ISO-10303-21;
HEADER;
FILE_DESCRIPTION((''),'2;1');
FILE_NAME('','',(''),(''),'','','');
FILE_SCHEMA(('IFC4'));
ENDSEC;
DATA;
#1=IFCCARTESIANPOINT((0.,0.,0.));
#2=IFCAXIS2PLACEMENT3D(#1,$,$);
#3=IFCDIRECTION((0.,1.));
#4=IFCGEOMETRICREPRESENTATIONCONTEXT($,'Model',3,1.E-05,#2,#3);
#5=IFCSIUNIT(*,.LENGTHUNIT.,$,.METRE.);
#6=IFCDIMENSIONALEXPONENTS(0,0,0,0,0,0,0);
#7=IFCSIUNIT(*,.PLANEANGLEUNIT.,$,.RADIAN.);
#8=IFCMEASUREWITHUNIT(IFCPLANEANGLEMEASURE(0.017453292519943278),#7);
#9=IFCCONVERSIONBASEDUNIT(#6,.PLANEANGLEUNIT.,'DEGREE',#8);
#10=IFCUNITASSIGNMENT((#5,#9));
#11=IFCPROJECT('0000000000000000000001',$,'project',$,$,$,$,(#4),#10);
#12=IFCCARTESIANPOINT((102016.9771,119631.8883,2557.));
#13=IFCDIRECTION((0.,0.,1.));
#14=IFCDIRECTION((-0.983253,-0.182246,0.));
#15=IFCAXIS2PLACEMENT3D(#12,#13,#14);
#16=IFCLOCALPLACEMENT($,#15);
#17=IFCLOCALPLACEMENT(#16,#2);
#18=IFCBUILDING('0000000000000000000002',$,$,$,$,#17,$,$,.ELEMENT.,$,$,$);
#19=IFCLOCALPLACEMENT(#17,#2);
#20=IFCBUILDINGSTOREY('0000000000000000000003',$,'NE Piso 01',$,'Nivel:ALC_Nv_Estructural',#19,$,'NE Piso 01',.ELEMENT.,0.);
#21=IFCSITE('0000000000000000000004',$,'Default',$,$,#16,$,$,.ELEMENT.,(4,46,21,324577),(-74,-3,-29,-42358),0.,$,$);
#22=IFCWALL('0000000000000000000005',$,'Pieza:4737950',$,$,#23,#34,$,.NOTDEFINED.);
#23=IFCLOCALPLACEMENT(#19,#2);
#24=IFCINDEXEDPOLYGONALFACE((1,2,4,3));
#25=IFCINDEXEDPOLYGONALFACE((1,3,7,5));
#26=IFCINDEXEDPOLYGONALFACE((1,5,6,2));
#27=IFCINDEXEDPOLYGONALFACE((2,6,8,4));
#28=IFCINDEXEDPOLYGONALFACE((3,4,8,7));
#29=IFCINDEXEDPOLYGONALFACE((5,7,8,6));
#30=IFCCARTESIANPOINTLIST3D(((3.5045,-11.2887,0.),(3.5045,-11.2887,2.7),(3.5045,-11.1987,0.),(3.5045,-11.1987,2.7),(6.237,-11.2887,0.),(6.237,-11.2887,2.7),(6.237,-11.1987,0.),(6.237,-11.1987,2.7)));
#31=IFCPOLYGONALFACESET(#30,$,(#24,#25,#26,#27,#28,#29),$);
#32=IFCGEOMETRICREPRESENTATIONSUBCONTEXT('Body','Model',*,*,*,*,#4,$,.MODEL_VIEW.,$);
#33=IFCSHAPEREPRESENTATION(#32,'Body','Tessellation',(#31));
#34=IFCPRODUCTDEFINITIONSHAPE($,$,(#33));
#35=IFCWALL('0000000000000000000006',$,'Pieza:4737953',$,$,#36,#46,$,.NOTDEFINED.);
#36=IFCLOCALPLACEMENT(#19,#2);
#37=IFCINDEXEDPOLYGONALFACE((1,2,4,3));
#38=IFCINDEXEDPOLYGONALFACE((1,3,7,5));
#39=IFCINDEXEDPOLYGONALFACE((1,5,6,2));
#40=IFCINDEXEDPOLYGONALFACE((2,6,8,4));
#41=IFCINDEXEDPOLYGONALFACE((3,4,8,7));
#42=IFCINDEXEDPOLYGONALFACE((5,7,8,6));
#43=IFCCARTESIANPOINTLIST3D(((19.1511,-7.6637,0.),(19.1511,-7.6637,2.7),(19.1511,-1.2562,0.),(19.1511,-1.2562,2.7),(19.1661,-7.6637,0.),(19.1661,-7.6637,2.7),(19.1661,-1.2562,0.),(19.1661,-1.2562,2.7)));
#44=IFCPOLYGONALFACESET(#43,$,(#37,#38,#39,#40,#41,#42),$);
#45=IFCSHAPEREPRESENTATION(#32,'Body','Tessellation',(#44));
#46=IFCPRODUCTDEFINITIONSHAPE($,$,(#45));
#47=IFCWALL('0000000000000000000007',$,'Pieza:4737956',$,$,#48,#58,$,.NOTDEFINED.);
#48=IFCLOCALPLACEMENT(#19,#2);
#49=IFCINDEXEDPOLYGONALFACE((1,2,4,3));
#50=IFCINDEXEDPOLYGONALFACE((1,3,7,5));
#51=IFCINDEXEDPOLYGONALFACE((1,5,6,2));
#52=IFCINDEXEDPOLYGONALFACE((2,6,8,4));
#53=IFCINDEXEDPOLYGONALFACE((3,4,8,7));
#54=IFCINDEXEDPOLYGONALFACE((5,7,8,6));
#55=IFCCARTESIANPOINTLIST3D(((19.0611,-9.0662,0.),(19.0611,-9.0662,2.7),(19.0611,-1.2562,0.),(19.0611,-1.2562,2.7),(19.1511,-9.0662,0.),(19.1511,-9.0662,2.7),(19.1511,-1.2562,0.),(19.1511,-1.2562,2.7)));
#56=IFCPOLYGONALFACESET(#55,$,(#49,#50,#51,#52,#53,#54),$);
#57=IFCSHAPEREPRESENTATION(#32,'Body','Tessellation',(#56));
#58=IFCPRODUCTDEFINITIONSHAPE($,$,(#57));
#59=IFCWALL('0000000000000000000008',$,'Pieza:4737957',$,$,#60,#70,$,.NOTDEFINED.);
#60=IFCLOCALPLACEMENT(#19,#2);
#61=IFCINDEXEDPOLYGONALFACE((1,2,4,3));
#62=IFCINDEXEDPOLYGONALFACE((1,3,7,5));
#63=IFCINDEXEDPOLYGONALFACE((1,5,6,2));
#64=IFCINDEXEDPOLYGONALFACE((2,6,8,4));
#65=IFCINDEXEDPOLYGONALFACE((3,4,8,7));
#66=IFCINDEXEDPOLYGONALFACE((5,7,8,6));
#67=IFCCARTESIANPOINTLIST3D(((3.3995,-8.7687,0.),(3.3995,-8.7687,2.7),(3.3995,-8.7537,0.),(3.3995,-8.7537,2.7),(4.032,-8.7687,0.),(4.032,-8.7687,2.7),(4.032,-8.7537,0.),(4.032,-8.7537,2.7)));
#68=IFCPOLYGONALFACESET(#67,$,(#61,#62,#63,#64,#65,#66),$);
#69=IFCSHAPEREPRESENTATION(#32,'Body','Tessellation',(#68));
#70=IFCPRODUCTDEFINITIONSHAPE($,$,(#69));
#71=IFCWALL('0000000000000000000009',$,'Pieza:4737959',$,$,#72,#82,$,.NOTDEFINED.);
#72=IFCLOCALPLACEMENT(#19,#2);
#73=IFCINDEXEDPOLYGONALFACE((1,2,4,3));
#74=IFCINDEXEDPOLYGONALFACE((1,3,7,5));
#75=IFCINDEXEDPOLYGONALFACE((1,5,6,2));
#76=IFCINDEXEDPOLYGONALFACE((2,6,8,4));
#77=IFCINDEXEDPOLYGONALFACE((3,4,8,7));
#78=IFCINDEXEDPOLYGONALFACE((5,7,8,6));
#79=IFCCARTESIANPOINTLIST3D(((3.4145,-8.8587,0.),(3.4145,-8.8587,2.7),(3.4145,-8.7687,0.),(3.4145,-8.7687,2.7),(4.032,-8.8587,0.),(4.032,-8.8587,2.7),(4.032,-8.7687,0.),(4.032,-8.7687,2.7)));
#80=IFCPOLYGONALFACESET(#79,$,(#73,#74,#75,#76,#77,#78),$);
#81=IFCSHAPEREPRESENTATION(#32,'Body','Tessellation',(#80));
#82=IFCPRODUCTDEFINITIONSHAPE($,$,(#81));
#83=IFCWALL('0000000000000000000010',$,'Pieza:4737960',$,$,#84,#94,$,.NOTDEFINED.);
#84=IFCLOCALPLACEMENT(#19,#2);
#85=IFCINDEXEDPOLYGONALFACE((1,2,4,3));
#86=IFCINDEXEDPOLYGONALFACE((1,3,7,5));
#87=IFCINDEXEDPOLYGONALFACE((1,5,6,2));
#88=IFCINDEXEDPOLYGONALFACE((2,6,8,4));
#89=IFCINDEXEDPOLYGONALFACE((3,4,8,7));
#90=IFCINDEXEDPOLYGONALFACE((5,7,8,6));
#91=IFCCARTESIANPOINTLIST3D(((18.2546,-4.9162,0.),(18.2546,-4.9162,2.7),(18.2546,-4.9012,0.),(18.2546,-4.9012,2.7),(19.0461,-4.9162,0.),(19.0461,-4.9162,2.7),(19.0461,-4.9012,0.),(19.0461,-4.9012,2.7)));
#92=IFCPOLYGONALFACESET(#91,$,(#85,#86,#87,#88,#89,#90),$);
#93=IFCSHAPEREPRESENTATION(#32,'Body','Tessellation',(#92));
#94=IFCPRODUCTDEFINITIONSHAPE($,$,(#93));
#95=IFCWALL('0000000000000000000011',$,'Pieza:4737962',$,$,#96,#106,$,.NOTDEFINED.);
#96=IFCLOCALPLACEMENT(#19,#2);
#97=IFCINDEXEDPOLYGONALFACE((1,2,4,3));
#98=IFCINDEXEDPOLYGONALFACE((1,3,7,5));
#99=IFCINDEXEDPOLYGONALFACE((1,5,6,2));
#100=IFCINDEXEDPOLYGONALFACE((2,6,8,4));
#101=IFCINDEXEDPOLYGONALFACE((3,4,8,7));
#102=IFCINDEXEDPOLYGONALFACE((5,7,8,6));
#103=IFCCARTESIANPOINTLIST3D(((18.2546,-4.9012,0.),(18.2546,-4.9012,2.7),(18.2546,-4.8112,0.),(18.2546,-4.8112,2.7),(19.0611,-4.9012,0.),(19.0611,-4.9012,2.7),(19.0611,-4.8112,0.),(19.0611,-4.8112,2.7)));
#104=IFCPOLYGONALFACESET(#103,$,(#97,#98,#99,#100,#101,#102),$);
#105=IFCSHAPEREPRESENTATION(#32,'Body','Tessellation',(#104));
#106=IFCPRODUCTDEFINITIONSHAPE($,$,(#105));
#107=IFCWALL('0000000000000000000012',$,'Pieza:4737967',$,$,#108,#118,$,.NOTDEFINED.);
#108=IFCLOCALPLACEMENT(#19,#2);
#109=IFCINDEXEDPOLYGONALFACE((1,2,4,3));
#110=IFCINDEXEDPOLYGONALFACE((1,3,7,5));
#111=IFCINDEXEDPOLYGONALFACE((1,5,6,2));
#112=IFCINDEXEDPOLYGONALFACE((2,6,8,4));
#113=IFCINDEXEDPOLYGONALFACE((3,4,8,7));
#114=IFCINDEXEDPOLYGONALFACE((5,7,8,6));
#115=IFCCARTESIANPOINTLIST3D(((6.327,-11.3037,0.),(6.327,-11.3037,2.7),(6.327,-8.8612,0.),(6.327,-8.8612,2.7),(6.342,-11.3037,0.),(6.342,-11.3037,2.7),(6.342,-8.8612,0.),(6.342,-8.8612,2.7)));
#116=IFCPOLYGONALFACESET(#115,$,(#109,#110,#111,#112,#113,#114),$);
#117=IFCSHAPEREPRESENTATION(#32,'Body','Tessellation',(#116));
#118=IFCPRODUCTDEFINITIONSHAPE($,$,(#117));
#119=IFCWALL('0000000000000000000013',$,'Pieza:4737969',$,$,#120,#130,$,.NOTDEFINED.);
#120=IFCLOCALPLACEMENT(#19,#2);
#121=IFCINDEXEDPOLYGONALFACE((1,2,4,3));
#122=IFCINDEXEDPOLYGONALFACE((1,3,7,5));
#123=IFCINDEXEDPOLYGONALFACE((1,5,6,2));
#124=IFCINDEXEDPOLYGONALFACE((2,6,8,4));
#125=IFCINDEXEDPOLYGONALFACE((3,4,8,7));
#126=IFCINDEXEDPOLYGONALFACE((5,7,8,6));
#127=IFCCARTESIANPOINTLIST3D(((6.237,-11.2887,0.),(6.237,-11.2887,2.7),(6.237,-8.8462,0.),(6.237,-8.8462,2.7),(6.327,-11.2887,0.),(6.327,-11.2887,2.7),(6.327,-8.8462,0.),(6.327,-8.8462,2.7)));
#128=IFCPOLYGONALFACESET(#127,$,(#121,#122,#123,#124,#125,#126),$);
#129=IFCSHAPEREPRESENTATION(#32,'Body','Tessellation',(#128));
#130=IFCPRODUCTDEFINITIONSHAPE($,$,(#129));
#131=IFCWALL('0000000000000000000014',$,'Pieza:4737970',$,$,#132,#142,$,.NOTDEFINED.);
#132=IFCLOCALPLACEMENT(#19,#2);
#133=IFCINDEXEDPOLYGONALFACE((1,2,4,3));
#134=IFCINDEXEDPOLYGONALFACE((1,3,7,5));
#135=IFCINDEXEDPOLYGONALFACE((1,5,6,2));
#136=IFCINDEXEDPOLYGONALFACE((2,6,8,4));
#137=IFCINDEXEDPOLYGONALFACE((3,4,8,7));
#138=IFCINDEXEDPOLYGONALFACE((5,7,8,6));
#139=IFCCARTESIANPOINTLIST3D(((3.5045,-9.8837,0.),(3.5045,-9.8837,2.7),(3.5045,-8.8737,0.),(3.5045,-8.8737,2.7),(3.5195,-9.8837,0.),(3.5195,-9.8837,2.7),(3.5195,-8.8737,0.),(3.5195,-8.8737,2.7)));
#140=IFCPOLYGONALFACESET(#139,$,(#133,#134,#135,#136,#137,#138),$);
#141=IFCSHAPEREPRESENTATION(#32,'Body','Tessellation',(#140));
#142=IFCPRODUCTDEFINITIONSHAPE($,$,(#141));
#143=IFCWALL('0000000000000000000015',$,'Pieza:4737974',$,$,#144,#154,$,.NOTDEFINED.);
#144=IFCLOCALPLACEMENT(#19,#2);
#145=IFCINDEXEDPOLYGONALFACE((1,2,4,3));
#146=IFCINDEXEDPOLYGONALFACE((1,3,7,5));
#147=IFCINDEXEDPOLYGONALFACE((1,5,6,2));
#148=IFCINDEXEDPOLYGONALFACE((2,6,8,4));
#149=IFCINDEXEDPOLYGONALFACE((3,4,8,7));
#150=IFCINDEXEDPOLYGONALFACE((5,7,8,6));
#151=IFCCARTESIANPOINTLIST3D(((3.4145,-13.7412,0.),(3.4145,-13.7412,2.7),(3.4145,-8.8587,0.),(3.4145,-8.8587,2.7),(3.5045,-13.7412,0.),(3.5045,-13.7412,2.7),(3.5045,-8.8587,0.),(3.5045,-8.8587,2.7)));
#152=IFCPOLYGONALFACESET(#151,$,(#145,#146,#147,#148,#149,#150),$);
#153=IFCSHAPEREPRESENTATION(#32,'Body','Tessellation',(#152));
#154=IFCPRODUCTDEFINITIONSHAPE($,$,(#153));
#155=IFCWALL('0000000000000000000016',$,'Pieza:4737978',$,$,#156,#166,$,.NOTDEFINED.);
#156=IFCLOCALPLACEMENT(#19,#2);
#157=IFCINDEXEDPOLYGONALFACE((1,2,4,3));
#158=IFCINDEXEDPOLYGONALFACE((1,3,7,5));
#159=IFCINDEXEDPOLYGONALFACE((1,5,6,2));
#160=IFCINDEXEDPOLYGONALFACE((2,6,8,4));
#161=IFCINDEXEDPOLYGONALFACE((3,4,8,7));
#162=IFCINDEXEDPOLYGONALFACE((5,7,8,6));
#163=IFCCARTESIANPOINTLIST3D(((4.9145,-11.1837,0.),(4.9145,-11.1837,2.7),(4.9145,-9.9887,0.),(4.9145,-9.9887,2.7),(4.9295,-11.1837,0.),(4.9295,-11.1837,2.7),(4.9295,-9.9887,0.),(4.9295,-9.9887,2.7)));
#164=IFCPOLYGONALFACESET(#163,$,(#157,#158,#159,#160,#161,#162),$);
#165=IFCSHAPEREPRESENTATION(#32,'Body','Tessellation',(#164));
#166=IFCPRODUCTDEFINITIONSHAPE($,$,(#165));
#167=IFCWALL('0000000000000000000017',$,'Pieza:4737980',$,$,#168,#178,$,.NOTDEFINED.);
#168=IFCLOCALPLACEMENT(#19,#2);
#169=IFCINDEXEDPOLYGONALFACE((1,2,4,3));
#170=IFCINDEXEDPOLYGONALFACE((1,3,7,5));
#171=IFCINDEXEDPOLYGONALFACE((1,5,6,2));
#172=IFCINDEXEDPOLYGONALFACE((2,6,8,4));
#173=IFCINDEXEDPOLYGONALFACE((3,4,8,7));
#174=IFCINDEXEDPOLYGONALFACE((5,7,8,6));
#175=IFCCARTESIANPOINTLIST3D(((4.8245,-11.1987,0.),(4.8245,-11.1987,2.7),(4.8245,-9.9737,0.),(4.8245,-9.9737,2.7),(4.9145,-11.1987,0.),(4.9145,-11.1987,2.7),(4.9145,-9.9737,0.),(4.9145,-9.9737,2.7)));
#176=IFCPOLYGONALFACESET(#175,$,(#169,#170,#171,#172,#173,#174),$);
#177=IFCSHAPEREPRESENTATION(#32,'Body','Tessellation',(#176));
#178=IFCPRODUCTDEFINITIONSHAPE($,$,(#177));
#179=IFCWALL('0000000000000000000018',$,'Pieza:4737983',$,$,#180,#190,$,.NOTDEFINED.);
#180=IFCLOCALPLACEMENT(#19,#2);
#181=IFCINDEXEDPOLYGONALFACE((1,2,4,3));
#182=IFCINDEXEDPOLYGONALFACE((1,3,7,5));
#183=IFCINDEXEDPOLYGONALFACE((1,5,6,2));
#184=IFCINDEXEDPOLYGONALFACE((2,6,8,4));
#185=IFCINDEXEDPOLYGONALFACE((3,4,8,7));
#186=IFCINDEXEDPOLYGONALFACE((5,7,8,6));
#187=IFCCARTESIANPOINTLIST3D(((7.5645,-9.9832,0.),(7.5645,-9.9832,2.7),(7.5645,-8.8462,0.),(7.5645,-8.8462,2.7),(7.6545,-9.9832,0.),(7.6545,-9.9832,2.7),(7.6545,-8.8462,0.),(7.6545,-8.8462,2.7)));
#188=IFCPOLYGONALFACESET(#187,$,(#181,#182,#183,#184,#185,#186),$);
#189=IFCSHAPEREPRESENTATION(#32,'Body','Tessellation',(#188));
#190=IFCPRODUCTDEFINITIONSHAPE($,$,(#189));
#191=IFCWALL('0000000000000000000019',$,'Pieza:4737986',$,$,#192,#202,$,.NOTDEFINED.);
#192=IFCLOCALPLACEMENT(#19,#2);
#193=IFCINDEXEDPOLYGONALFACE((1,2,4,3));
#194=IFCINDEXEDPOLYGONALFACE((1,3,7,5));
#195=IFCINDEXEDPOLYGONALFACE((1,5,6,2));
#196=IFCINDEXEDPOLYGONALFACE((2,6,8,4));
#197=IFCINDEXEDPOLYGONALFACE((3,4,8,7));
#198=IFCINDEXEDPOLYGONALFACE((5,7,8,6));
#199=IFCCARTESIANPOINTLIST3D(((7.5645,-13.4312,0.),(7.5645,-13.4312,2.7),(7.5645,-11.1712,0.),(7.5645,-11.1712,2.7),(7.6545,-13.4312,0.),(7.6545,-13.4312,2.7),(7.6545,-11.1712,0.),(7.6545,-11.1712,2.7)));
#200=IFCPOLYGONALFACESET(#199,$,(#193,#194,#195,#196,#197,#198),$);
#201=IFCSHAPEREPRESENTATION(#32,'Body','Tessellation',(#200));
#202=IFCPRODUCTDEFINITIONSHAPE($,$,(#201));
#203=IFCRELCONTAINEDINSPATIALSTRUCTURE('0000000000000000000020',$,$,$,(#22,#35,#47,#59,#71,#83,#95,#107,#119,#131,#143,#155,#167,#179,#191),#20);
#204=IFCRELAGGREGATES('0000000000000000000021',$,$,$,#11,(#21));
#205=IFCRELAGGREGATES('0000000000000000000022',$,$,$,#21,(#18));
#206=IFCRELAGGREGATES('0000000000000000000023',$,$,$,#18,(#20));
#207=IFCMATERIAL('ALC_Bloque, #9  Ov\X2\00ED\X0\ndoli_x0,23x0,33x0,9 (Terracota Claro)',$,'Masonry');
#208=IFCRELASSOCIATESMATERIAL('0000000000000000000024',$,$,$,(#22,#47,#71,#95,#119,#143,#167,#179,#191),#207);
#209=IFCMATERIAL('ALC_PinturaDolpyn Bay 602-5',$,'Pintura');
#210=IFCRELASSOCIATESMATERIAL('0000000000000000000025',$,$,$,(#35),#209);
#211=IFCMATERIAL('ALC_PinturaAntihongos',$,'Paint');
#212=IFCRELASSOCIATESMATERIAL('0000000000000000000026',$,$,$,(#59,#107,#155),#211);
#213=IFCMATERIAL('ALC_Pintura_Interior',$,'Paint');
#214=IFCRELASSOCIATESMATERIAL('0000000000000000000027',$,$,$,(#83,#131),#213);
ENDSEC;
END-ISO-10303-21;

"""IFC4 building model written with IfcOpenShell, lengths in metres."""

from ifc_helpers import new_model, entity, si_unit, converted_unit, direction, frame, frame_2d, origin, place, context, subcontext, project, spatial, rectangle, extrude, material, element, save


model = new_model("IFC4")

# Units and contexts
model_context = context("Model", 3, precision=1e-05, world=origin(), true_north=direction((0.0, 1.0)))
body_context = subcontext(model_context, "Body", "Model", "MODEL_VIEW")
ifc_project = project(units=[si_unit("LENGTHUNIT", "METRE"), converted_unit("PLANEANGLEUNIT", "DEGREE", entity("IfcPlaneAngleMeasure", 0.017453292519943278), si_unit("PLANEANGLEUNIT", "RADIAN"), dimensions=[0, 0, 0, 0, 0, 0, 0])], contexts=[model_context])

# Site, building, storey
site_placement = place(None, frame((102016.9771, 119631.8883, 2557.0), z_axis=(0.0, 0.0, 1.0), x_axis=(-0.983253, -0.182246, 0.0)))
site = spatial("IfcSite", under=ifc_project, at=site_placement, Name="Default", CompositionType="ELEMENT", RefLatitude=(4, 46, 21, 324577), RefLongitude=(-74, -3, -29, -42358), RefElevation=0.0)
building_placement = place(site_placement, origin())
building = spatial("IfcBuilding", under=site, at=building_placement, CompositionType="ELEMENT")
storey_placement = place(building_placement, origin())
storey = spatial("IfcBuildingStorey", under=building, at=storey_placement, Name="NE Piso 01", ObjectType="Nivel:ALC_Nv_Estructural", LongName="NE Piso 01", CompositionType="ELEMENT", Elevation=0.0)

# Walls
ifc_material_1 = material(Name="ALC_Bloque, #9  Ovíndoli_x0,23x0,33x0,9 (Terracota Claro)", Category="Masonry")
ifc_material_2 = material(Name="ALC_Pintura_Interior", Category="Paint")
ifc_material_3 = material(Name="ALC_PinturaAntihongos", Category="Paint")
wall_1_placement = place(storey_placement, origin())
element("IfcWall", 1, at=wall_1_placement, inside=storey, material=ifc_material_1, Name="Pieza:4737950", PredefinedType="NOTDEFINED", context=body_context, shape_type="SweptSolid", body=[
    extrude(rectangle(XDim=0.09, YDim=2.7325, at=frame_2d((0.0, 0.0), x_axis=(1.0, 0.0))), frame((4.8708, -11.2437, 0.0), z_axis=(0.0, 0.0, 1.0), x_axis=(0.0, -1.0, 0.0)), (0.0, 0.0, 1.0), 2.7),
])
ifc_material_4 = material(Name="ALC_PinturaDolpyn Bay 602-5", Category="Pintura")
wall_2_placement = place(storey_placement, origin())
element("IfcWall", 2, at=wall_2_placement, inside=storey, material=ifc_material_4, Name="Pieza:4737953", PredefinedType="NOTDEFINED", context=body_context, shape_type="SweptSolid", body=[
    extrude(rectangle(XDim=6.4075, YDim=0.015, at=frame_2d((0.0, 0.0), x_axis=(1.0, 0.0))), frame((19.1586, -4.4599, 0.0), z_axis=(0.0, 0.0, 1.0), x_axis=(0.0, -1.0, 0.0)), (0.0, 0.0, 1.0), 2.7),
])
wall_3_placement = place(storey_placement, origin())
element("IfcWall", 3, at=wall_3_placement, inside=storey, material=ifc_material_1, Name="Pieza:4737956", PredefinedType="NOTDEFINED", context=body_context, shape_type="SweptSolid", body=[
    extrude(rectangle(XDim=7.81, YDim=0.09, at=frame_2d((0.0, 0.0), x_axis=(1.0, 0.0))), frame((19.1061, -5.1612, 0.0), z_axis=(0.0, 0.0, 1.0), x_axis=(0.0, -1.0, 0.0)), (0.0, 0.0, 1.0), 2.7),
])
wall_4_placement = place(storey_placement, origin())
element("IfcWall", 4, at=wall_4_placement, inside=storey, material=ifc_material_3, Name="Pieza:4737957", PredefinedType="NOTDEFINED", context=body_context, shape_type="SweptSolid", body=[
    extrude(rectangle(XDim=0.015, YDim=0.6325, at=frame_2d((0.0, 0.0), x_axis=(1.0, 0.0))), frame((3.7158, -8.7612, 0.0), z_axis=(0.0, 0.0, 1.0), x_axis=(0.0, -1.0, 0.0)), (0.0, 0.0, 1.0), 2.7),
])
wall_5_placement = place(storey_placement, origin())
element("IfcWall", 5, at=wall_5_placement, inside=storey, material=ifc_material_1, Name="Pieza:4737959", PredefinedType="NOTDEFINED", context=body_context, shape_type="SweptSolid", body=[
    extrude(rectangle(XDim=0.09, YDim=0.6175, at=frame_2d((0.0, 0.0), x_axis=(1.0, 0.0))), frame((3.7233, -8.8137, 0.0), z_axis=(0.0, 0.0, 1.0), x_axis=(0.0, -1.0, 0.0)), (0.0, 0.0, 1.0), 2.7),
])
wall_6_placement = place(storey_placement, origin())
element("IfcWall", 6, at=wall_6_placement, inside=storey, material=ifc_material_2, Name="Pieza:4737960", PredefinedType="NOTDEFINED", context=body_context, shape_type="SweptSolid", body=[
    extrude(rectangle(XDim=0.015, YDim=0.7915, at=frame_2d((0.0, 0.0), x_axis=(1.0, 0.0))), frame((18.6504, -4.9087, 0.0), z_axis=(0.0, 0.0, 1.0), x_axis=(0.0, -1.0, 0.0)), (0.0, 0.0, 1.0), 2.7),
])
wall_7_placement = place(storey_placement, origin())
element("IfcWall", 7, at=wall_7_placement, inside=storey, material=ifc_material_1, Name="Pieza:4737962", PredefinedType="NOTDEFINED", context=body_context, shape_type="SweptSolid", body=[
    extrude(rectangle(XDim=0.09, YDim=0.8065, at=frame_2d((0.0, 0.0), x_axis=(1.0, 0.0))), frame((18.6579, -4.8562, 0.0), z_axis=(0.0, 0.0, 1.0), x_axis=(0.0, -1.0, 0.0)), (0.0, 0.0, 1.0), 2.7),
])
wall_8_placement = place(storey_placement, origin())
element("IfcWall", 8, at=wall_8_placement, inside=storey, material=ifc_material_3, Name="Pieza:4737967", PredefinedType="NOTDEFINED", context=body_context, shape_type="SweptSolid", body=[
    extrude(rectangle(XDim=2.4425, YDim=0.015, at=frame_2d((0.0, 0.0), x_axis=(1.0, 0.0))), frame((6.3345, -10.0824, 0.0), z_axis=(0.0, 0.0, 1.0), x_axis=(0.0, -1.0, 0.0)), (0.0, 0.0, 1.0), 2.7),
])
wall_9_placement = place(storey_placement, origin())
element("IfcWall", 9, at=wall_9_placement, inside=storey, material=ifc_material_1, Name="Pieza:4737969", PredefinedType="NOTDEFINED", context=body_context, shape_type="SweptSolid", body=[
    extrude(rectangle(XDim=2.4425, YDim=0.09, at=frame_2d((0.0, 0.0), x_axis=(1.0, 0.0))), frame((6.282, -10.0674, 0.0), z_axis=(0.0, 0.0, 1.0), x_axis=(0.0, -1.0, 0.0)), (0.0, 0.0, 1.0), 2.7),
])
wall_10_placement = place(storey_placement, origin())
element("IfcWall", 10, at=wall_10_placement, inside=storey, material=ifc_material_2, Name="Pieza:4737970", PredefinedType="NOTDEFINED", context=body_context, shape_type="SweptSolid", body=[
    extrude(rectangle(XDim=1.01, YDim=0.015, at=frame_2d((0.0, 0.0), x_axis=(1.0, 0.0))), frame((3.512, -9.3787, 0.0), z_axis=(0.0, 0.0, 1.0), x_axis=(0.0, -1.0, 0.0)), (0.0, 0.0, 1.0), 2.7),
])
wall_11_placement = place(storey_placement, origin())
element("IfcWall", 11, at=wall_11_placement, inside=storey, material=ifc_material_1, Name="Pieza:4737974", PredefinedType="NOTDEFINED", context=body_context, shape_type="SweptSolid", body=[
    extrude(rectangle(XDim=4.8825, YDim=0.09, at=frame_2d((0.0, 0.0), x_axis=(1.0, 0.0))), frame((3.4595, -11.2999, 0.0), z_axis=(0.0, 0.0, 1.0), x_axis=(0.0, -1.0, 0.0)), (0.0, 0.0, 1.0), 2.7),
])
wall_12_placement = place(storey_placement, origin())
element("IfcWall", 12, at=wall_12_placement, inside=storey, material=ifc_material_3, Name="Pieza:4737978", PredefinedType="NOTDEFINED", context=body_context, shape_type="SweptSolid", body=[
    extrude(rectangle(XDim=1.195, YDim=0.015, at=frame_2d((0.0, 0.0), x_axis=(1.0, 0.0))), frame((4.922, -10.5862, 0.0), z_axis=(0.0, 0.0, 1.0), x_axis=(0.0, -1.0, 0.0)), (0.0, 0.0, 1.0), 2.7),
])
wall_13_placement = place(storey_placement, origin())
element("IfcWall", 13, at=wall_13_placement, inside=storey, material=ifc_material_1, Name="Pieza:4737980", PredefinedType="NOTDEFINED", context=body_context, shape_type="SweptSolid", body=[
    extrude(rectangle(XDim=1.225, YDim=0.09, at=frame_2d((0.0, 0.0), x_axis=(1.0, 0.0))), frame((4.8695, -10.5862, 0.0), z_axis=(0.0, 0.0, 1.0), x_axis=(0.0, -1.0, 0.0)), (0.0, 0.0, 1.0), 2.7),
])
wall_14_placement = place(storey_placement, origin())
element("IfcWall", 14, at=wall_14_placement, inside=storey, material=ifc_material_1, Name="Pieza:4737983", PredefinedType="NOTDEFINED", context=body_context, shape_type="SweptSolid", body=[
    extrude(rectangle(XDim=1.137, YDim=0.09, at=frame_2d((0.0, 0.0), x_axis=(1.0, 0.0))), frame((7.6095, -9.4147, 0.0), z_axis=(0.0, 0.0, 1.0), x_axis=(0.0, -1.0, 0.0)), (0.0, 0.0, 1.0), 2.7),
])
wall_15_placement = place(storey_placement, origin())
element("IfcWall", 15, at=wall_15_placement, inside=storey, material=ifc_material_1, Name="Pieza:4737986", PredefinedType="NOTDEFINED", context=body_context, shape_type="SweptSolid", body=[
    extrude(rectangle(XDim=2.26, YDim=0.09, at=frame_2d((0.0, 0.0), x_axis=(1.0, 0.0))), frame((7.6095, -12.3012, 0.0), z_axis=(0.0, 0.0, 1.0), x_axis=(0.0, -1.0, 0.0)), (0.0, 0.0, 1.0), 2.7),
])

save(model, "model.ifc")
